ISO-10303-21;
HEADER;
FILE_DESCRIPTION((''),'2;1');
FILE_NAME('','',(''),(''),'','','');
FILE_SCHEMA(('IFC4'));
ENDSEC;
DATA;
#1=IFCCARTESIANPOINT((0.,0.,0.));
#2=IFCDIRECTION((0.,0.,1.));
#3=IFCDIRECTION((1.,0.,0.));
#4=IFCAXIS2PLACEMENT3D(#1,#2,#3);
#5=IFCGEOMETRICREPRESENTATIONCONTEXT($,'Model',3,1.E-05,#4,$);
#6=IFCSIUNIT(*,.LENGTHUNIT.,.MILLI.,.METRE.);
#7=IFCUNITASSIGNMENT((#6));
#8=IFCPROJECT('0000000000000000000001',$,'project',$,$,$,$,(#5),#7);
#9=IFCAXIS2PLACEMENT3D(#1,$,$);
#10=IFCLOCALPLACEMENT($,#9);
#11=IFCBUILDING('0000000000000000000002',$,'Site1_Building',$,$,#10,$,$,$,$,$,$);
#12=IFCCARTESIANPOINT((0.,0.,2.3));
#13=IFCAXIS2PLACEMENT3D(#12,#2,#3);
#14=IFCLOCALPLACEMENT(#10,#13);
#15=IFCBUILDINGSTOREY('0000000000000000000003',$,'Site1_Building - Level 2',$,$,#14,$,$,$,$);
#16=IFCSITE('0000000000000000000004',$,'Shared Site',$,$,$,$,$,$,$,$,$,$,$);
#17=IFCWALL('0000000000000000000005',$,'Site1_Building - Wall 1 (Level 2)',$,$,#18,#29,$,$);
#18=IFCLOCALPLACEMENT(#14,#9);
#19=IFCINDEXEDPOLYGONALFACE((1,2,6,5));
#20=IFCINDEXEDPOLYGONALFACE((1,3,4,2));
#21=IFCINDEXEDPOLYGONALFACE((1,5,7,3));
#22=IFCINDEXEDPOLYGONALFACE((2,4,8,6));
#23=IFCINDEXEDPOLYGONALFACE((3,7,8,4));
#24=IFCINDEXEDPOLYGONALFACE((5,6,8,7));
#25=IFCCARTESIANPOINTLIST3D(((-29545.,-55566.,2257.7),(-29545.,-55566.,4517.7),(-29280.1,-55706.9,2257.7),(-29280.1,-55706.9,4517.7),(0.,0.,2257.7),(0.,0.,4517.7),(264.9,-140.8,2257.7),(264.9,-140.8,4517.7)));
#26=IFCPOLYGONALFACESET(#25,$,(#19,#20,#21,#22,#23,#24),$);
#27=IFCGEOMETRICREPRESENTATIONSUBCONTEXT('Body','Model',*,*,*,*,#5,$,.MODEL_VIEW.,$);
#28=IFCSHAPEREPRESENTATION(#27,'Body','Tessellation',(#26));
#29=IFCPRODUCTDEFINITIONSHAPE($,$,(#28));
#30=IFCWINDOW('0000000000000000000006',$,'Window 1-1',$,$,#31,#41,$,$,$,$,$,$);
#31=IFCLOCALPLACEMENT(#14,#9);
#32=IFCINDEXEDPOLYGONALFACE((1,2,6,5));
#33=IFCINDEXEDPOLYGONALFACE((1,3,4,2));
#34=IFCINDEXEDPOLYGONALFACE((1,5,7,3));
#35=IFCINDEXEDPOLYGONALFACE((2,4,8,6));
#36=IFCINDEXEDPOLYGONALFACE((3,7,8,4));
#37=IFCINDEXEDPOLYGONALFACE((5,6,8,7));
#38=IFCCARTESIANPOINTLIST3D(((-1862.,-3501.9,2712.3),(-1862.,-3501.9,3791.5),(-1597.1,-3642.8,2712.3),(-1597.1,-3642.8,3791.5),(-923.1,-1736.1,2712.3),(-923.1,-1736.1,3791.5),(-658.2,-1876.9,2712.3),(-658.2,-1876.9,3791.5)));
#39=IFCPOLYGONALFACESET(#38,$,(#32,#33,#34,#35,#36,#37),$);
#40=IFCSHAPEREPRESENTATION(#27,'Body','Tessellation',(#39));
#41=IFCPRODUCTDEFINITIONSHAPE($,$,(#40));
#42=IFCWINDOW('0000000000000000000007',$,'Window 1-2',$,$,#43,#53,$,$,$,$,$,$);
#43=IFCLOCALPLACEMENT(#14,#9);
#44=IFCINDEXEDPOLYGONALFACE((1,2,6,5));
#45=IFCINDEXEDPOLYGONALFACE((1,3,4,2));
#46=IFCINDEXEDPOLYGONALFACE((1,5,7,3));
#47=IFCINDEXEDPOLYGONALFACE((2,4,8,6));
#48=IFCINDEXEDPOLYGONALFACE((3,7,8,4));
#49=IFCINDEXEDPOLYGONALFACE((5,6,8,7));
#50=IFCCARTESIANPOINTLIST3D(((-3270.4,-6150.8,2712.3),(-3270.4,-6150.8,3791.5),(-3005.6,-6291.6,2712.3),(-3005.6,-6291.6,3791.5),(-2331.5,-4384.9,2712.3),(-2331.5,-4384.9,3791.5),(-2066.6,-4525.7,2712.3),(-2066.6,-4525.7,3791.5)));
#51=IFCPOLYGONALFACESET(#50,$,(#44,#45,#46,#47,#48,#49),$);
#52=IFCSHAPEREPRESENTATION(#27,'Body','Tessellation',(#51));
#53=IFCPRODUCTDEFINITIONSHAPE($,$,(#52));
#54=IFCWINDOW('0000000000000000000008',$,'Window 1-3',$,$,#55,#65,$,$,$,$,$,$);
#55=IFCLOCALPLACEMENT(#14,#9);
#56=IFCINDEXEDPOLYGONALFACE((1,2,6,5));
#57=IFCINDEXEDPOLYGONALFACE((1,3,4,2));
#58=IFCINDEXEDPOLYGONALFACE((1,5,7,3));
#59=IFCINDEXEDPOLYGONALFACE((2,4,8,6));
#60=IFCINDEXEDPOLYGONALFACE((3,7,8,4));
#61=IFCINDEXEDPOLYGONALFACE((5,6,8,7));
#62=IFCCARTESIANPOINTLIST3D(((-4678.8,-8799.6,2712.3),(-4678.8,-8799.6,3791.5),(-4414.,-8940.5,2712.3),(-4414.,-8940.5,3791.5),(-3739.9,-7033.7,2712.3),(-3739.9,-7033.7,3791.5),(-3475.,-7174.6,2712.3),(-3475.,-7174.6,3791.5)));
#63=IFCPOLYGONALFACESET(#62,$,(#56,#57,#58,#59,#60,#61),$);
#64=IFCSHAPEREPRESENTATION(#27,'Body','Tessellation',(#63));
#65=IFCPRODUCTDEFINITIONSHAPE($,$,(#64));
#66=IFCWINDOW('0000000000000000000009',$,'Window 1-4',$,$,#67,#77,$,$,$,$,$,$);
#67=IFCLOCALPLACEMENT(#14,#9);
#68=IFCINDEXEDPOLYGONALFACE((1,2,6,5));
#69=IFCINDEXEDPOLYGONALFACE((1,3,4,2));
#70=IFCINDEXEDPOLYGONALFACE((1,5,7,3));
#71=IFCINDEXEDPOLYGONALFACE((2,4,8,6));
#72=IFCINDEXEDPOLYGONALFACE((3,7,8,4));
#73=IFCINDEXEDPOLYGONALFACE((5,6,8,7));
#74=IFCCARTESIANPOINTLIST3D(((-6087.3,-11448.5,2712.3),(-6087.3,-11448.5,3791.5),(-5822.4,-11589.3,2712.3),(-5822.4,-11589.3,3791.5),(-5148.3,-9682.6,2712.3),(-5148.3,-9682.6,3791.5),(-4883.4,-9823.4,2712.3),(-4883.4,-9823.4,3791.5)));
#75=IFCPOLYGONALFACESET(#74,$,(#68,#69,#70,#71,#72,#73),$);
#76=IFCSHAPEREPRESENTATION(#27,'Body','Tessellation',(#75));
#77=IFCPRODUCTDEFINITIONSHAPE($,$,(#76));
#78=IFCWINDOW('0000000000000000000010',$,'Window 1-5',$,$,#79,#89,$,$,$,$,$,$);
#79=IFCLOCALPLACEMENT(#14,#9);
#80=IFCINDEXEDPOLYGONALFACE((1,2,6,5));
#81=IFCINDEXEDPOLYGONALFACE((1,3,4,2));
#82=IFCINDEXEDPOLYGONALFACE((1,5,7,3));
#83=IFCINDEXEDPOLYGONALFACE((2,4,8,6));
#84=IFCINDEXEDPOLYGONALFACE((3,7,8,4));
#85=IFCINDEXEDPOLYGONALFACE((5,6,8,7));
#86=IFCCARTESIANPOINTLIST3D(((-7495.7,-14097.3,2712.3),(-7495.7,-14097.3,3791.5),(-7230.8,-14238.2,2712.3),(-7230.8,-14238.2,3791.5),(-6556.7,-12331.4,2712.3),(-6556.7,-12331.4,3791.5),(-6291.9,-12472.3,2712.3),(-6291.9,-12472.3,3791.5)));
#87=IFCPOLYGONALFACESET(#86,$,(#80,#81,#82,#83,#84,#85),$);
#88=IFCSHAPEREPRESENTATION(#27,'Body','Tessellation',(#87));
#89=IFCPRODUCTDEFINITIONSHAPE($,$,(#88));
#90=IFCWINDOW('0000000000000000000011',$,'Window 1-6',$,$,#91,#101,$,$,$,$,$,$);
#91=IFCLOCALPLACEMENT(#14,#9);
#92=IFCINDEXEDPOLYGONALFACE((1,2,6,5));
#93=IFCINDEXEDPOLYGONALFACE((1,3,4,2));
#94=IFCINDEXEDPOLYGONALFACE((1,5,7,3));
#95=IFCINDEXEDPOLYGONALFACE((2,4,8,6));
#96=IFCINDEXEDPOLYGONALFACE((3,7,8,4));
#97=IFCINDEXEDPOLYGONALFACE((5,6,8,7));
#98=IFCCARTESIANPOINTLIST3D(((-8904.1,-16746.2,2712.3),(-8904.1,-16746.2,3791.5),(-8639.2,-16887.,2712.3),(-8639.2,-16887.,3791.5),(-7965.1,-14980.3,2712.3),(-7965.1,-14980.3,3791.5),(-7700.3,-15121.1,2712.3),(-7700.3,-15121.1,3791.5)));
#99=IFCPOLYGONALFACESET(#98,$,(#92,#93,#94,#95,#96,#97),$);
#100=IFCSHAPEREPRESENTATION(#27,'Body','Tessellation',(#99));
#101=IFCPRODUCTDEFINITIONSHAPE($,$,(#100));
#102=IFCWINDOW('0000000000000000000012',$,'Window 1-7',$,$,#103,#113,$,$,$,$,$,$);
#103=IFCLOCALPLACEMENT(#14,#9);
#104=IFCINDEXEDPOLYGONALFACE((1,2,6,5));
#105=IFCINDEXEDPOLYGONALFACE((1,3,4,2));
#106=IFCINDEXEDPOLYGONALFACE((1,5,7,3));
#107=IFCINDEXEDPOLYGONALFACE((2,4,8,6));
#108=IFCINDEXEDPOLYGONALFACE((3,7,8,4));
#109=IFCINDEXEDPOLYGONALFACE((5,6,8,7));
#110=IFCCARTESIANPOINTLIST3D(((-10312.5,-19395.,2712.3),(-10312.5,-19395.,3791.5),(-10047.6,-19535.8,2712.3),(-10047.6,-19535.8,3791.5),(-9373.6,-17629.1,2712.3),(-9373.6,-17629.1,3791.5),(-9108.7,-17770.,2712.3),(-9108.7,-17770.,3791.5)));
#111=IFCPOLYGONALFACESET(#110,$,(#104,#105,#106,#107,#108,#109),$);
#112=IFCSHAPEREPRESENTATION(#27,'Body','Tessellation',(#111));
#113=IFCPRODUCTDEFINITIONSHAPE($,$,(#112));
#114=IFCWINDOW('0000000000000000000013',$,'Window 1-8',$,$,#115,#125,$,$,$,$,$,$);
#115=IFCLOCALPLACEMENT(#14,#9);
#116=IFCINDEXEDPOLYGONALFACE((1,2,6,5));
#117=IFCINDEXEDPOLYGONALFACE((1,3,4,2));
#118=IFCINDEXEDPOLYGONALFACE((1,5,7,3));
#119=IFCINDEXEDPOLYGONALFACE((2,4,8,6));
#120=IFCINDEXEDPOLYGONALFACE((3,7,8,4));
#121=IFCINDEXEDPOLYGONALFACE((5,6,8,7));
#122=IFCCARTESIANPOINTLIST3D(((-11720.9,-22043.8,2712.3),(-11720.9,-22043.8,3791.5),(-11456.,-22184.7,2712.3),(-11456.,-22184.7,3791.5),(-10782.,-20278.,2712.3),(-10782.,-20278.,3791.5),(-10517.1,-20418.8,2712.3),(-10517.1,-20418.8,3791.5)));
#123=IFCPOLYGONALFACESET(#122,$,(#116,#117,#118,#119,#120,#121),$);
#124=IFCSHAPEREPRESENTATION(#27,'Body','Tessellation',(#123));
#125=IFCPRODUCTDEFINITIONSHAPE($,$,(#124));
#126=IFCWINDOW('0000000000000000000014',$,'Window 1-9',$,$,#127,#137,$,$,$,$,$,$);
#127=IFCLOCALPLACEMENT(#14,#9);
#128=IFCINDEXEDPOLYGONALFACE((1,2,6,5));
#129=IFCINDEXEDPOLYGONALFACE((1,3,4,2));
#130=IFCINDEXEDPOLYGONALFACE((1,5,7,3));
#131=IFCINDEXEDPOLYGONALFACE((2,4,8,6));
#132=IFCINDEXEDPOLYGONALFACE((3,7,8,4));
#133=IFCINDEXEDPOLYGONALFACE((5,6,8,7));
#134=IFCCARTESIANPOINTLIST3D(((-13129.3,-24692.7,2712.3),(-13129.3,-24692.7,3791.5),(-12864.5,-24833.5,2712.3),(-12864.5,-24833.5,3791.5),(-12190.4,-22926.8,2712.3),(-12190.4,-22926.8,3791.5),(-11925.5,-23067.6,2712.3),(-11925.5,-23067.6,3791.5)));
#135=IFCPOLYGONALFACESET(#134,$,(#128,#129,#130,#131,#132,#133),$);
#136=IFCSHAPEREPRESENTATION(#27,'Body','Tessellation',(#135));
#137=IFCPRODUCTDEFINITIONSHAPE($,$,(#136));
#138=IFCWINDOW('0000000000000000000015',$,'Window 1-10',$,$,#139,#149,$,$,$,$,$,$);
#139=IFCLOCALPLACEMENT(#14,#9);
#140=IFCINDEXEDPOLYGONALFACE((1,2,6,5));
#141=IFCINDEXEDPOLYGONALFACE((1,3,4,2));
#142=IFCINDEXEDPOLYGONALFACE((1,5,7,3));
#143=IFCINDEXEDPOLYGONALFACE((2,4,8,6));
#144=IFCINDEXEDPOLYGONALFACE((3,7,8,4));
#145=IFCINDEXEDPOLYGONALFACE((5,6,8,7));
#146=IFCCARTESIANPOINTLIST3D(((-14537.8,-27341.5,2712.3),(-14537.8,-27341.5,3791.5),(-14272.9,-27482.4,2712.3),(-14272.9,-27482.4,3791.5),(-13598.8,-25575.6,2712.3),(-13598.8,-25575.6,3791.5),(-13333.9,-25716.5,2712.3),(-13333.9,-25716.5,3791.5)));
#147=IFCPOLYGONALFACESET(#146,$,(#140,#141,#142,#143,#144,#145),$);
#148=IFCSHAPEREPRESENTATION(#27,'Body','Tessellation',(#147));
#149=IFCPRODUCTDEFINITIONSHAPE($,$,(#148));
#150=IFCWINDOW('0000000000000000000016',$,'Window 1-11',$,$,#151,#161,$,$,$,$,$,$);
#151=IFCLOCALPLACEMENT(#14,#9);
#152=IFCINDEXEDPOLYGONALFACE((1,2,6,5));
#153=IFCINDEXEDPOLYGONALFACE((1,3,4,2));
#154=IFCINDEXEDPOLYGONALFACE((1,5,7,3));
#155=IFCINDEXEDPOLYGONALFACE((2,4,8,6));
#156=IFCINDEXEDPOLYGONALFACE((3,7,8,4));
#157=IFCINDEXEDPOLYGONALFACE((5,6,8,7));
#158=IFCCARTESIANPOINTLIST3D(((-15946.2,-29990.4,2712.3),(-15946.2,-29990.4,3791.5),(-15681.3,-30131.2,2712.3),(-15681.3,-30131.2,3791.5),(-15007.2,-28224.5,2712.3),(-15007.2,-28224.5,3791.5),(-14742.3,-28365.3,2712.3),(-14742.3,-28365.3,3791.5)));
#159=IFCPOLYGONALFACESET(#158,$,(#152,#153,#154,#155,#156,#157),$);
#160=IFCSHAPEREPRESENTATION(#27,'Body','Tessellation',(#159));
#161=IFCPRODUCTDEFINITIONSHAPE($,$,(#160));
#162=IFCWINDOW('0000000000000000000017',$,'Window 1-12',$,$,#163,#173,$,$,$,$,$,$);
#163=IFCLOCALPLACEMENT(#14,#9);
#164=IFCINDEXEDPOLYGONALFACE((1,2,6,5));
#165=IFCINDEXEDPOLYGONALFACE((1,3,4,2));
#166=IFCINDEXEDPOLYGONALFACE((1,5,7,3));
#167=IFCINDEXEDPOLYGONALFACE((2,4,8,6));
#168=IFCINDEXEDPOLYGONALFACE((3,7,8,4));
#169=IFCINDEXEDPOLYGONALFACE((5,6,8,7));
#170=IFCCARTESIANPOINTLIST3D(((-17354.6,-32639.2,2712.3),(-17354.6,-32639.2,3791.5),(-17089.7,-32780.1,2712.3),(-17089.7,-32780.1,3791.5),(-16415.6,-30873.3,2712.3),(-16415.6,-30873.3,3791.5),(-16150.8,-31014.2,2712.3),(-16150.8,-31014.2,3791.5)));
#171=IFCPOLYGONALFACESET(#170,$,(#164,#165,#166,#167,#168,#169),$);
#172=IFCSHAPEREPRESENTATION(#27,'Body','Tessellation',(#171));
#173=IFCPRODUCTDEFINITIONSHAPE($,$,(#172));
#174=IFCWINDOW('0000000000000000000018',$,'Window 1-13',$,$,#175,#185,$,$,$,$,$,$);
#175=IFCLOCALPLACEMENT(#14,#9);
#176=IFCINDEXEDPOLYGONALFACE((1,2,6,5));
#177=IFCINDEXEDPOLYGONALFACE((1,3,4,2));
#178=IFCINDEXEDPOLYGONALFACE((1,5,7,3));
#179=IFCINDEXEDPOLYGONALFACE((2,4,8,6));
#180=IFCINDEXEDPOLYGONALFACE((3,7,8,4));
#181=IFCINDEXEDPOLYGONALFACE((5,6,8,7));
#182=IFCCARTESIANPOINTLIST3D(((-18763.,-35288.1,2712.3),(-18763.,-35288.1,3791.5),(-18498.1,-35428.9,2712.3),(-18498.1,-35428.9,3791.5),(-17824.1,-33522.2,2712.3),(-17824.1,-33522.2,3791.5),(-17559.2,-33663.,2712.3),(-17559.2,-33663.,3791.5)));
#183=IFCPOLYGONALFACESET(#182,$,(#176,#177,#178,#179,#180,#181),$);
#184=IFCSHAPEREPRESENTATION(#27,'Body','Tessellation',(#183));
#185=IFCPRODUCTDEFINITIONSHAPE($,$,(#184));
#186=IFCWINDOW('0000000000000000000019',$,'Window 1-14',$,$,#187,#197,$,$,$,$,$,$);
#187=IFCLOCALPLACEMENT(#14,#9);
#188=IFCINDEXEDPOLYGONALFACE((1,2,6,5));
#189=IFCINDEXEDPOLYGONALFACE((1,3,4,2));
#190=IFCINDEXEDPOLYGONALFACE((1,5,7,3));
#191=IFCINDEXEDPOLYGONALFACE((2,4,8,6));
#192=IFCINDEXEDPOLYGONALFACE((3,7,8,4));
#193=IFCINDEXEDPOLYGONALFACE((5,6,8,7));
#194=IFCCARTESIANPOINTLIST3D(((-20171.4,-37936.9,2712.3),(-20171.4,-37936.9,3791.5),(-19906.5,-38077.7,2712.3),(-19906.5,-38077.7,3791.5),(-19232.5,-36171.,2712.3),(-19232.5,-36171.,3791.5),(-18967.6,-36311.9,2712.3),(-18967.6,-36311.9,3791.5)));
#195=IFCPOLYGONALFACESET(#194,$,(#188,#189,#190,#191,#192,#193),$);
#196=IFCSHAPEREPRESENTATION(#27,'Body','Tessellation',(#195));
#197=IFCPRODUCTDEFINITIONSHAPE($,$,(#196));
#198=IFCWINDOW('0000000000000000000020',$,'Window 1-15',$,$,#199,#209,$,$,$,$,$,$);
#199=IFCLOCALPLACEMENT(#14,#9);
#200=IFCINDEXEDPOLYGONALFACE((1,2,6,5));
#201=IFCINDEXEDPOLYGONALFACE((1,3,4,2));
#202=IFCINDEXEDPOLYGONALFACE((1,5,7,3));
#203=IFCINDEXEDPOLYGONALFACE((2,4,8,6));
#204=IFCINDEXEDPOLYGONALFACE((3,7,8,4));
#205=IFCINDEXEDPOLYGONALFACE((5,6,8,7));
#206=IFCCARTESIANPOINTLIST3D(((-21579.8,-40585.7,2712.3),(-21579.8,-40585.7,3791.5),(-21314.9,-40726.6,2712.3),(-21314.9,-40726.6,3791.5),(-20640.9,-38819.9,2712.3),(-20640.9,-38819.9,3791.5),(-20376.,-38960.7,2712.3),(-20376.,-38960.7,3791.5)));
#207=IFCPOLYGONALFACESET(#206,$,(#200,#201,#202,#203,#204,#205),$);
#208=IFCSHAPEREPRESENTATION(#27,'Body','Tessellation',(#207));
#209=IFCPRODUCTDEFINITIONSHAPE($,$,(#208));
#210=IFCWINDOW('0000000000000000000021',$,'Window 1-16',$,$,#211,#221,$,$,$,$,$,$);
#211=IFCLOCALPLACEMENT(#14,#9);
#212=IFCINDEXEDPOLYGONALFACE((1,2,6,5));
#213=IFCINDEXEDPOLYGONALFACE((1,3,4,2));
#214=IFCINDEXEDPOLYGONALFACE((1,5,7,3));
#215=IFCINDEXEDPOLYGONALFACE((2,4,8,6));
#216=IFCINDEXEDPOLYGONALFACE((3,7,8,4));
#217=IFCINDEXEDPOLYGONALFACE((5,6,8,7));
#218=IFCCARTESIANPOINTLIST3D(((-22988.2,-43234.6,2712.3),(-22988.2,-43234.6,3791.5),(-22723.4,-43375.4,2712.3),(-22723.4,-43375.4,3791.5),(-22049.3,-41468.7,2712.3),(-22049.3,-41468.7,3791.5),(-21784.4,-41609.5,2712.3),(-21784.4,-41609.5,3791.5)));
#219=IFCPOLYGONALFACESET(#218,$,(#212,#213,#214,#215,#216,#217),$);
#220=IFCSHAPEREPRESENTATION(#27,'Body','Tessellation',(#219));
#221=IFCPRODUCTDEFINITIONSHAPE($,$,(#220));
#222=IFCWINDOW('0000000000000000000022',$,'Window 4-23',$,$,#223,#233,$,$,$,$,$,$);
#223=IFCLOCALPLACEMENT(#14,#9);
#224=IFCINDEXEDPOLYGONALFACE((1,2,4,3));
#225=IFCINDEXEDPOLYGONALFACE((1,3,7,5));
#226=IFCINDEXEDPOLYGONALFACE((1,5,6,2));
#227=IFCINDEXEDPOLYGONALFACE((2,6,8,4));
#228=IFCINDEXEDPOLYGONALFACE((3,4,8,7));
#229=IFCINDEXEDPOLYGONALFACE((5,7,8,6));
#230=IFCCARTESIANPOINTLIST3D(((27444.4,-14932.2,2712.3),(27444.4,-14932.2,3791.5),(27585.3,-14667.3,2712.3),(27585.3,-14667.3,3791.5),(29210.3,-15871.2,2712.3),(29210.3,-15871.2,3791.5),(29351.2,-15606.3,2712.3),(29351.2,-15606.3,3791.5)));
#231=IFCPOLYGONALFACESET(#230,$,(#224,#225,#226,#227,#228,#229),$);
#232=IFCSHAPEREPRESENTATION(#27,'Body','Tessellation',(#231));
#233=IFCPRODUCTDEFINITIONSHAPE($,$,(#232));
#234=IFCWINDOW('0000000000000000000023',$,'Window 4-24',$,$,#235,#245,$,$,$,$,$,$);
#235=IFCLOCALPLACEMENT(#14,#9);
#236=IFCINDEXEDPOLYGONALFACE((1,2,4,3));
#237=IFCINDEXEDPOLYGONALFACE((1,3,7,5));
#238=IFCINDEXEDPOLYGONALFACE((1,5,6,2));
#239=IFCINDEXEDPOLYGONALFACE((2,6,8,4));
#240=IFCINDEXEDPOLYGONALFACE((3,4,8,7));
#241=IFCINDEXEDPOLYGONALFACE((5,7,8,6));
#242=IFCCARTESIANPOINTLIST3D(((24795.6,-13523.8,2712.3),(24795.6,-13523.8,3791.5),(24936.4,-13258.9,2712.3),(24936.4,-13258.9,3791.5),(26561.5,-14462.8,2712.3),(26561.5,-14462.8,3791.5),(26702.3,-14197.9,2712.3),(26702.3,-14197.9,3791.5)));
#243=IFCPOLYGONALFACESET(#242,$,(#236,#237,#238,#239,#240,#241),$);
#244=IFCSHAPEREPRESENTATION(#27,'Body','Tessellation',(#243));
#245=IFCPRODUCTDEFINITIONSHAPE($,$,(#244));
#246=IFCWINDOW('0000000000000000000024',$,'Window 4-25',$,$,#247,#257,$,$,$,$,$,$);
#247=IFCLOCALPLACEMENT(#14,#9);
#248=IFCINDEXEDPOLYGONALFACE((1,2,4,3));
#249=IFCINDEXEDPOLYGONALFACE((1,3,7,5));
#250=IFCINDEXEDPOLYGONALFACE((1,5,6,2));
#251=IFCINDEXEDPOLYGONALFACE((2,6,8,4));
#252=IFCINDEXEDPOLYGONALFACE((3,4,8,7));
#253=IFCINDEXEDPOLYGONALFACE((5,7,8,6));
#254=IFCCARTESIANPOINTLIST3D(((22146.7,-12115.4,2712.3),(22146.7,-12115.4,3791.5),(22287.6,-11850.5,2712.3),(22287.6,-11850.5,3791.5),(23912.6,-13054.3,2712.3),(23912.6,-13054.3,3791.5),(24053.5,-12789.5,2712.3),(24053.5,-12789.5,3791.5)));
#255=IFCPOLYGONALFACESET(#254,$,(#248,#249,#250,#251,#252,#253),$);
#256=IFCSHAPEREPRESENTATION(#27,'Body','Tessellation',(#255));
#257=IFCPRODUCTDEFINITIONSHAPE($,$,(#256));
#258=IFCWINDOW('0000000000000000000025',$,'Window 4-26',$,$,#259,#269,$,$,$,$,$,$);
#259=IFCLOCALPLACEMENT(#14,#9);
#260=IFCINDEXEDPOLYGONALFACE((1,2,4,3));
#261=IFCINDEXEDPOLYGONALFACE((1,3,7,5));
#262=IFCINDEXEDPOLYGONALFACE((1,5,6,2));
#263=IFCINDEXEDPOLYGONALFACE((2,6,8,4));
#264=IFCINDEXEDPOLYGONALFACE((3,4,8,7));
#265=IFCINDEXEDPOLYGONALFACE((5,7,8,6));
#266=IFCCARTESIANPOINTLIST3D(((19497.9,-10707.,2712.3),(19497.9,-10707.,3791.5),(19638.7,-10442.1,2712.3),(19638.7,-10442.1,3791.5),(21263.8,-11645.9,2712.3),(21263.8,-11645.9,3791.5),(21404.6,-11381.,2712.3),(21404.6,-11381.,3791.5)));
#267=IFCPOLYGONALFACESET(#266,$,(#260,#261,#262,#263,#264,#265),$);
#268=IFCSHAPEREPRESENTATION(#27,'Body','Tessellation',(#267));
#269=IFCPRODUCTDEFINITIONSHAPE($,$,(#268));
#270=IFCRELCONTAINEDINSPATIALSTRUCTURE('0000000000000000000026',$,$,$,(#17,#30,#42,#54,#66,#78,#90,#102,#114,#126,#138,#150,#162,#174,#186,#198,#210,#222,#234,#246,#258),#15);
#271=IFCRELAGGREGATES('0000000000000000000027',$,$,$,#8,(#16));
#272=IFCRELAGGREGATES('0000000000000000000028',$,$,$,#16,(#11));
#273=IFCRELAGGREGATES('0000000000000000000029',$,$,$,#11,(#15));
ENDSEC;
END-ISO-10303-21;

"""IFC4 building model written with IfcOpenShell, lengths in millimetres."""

from ifc_helpers import new_model, si_unit, frame, origin, origin_with_axes, place, context, subcontext, project, spatial, indexed_curve, outline, extrude, element, save


model = new_model("IFC4")

# Units and contexts
model_context = context("Model", 3, precision=1e-05, world=origin_with_axes())
body_context = subcontext(model_context, "Body", "Model", "MODEL_VIEW")
ifc_project = project(units=[si_unit("LENGTHUNIT", "METRE", prefix="MILLI")], contexts=[model_context])

# Site, building, storey
site = spatial("IfcSite", under=ifc_project, Name="Shared Site")
building_placement = place(None, origin())
building = spatial("IfcBuilding", under=site, at=building_placement, Name="Site1_Building")
storey_placement = place(building_placement, frame((0.0, 0.0, 2.3), z_axis=(0.0, 0.0, 1.0), x_axis=(1.0, 0.0, 0.0)))
storey = spatial("IfcBuildingStorey", under=building, at=storey_placement, Name="Site1_Building - Level 2")

# Wall
wall_placement = place(storey_placement, frame((0.0, 0.0, 2257.7), z_axis=(0.0, 0.0, 1.0), x_axis=(-0.469472, -0.882948, 0.0)))
element("IfcWall", 1, at=wall_placement, inside=storey, Name="Site1_Building - Wall 1 (Level 2)", context=body_context, shape_type="SweptSolid", body=[
    extrude(outline(indexed_curve([(0.0, 0.0), (0.0, 300.0), (62932.4, 300.0), (62932.4, 0.0), (0.0, 0.0)], self_intersect=False)), origin_with_axes(), (0.0, 0.0, 1.0), 2260.0),
])

# Windows
for number, where, z_axis, x_axis, name in (
    (2, (-923.1, -1736.1, 2712.3), (0.0, 0.0, 1.0), (-0.469472, -0.882948, 0.0), "Window 1-1"),
    (3, (-2331.5, -4384.9, 2712.3), (0.0, 0.0, 1.0), (-0.469472, -0.882948, 0.0), "Window 1-2"),
    (4, (-3739.9, -7033.7, 2712.3), (0.0, 0.0, 1.0), (-0.469472, -0.882948, 0.0), "Window 1-3"),
    (5, (-5148.3, -9682.6, 2712.3), (0.0, 0.0, 1.0), (-0.469472, -0.882948, 0.0), "Window 1-4"),
    (6, (-6556.7, -12331.4, 2712.3), (0.0, 0.0, 1.0), (-0.469472, -0.882948, 0.0), "Window 1-5"),
    (7, (-7965.1, -14980.3, 2712.3), (0.0, 0.0, 1.0), (-0.469472, -0.882948, 0.0), "Window 1-6"),
    (8, (-9373.6, -17629.1, 2712.3), (0.0, 0.0, 1.0), (-0.469472, -0.882948, 0.0), "Window 1-7"),
    (9, (-10782.0, -20278.0, 2712.3), (0.0, 0.0, 1.0), (-0.469472, -0.882948, 0.0), "Window 1-8"),
    (10, (-12190.4, -22926.8, 2712.3), (0.0, 0.0, 1.0), (-0.469472, -0.882948, 0.0), "Window 1-9"),
    (11, (-13598.8, -25575.6, 2712.3), (0.0, 0.0, 1.0), (-0.469472, -0.882948, 0.0), "Window 1-10"),
    (12, (-15007.2, -28224.5, 2712.3), (0.0, 0.0, 1.0), (-0.469472, -0.882948, 0.0), "Window 1-11"),
    (13, (-16415.6, -30873.3, 2712.3), (0.0, 0.0, 1.0), (-0.469472, -0.882948, 0.0), "Window 1-12"),
    (14, (-17824.1, -33522.2, 2712.3), (0.0, 0.0, 1.0), (-0.469472, -0.882948, 0.0), "Window 1-13"),
    (15, (-19232.5, -36171.0, 2712.3), (0.0, 0.0, 1.0), (-0.469472, -0.882948, 0.0), "Window 1-14"),
    (16, (-20640.9, -38819.9, 2712.3), (0.0, 0.0, 1.0), (-0.469472, -0.882948, 0.0), "Window 1-15"),
    (17, (-22049.3, -41468.7, 2712.3), (0.0, 0.0, 1.0), (-0.469472, -0.882948, 0.0), "Window 1-16"),
    (18, (29351.2, -15606.3, 2712.3), (0.0, 0.0, 1.0), (-0.882948, 0.469472, 0.0), "Window 4-23"),
    (19, (26702.3, -14197.9, 2712.3), (0.0, 0.0, 1.0), (-0.882948, 0.469472, 0.0), "Window 4-24"),
    (20, (24053.5, -12789.5, 2712.3), (0.0, 0.0, 1.0), (-0.882948, 0.469472, 0.0), "Window 4-25"),
    (21, (21404.6, -11381.0, 2712.3), (0.0, 0.0, 1.0), (-0.882948, 0.469472, 0.0), "Window 4-26"),
):
    element("IfcWindow", number, at=place(storey_placement, frame(where, z_axis=z_axis, x_axis=x_axis)), inside=storey, Name=name, context=body_context, shape_type="SweptSolid", body=[
        extrude(outline(indexed_curve([(0.0, 0.0), (0.0, 300.0), (2000.0, 300.0), (2000.0, 0.0), (0.0, 0.0)], self_intersect=False)), origin_with_axes(), (0.0, 0.0, 1.0), 1079.3),
    ])

save(model, "model.ifc")
